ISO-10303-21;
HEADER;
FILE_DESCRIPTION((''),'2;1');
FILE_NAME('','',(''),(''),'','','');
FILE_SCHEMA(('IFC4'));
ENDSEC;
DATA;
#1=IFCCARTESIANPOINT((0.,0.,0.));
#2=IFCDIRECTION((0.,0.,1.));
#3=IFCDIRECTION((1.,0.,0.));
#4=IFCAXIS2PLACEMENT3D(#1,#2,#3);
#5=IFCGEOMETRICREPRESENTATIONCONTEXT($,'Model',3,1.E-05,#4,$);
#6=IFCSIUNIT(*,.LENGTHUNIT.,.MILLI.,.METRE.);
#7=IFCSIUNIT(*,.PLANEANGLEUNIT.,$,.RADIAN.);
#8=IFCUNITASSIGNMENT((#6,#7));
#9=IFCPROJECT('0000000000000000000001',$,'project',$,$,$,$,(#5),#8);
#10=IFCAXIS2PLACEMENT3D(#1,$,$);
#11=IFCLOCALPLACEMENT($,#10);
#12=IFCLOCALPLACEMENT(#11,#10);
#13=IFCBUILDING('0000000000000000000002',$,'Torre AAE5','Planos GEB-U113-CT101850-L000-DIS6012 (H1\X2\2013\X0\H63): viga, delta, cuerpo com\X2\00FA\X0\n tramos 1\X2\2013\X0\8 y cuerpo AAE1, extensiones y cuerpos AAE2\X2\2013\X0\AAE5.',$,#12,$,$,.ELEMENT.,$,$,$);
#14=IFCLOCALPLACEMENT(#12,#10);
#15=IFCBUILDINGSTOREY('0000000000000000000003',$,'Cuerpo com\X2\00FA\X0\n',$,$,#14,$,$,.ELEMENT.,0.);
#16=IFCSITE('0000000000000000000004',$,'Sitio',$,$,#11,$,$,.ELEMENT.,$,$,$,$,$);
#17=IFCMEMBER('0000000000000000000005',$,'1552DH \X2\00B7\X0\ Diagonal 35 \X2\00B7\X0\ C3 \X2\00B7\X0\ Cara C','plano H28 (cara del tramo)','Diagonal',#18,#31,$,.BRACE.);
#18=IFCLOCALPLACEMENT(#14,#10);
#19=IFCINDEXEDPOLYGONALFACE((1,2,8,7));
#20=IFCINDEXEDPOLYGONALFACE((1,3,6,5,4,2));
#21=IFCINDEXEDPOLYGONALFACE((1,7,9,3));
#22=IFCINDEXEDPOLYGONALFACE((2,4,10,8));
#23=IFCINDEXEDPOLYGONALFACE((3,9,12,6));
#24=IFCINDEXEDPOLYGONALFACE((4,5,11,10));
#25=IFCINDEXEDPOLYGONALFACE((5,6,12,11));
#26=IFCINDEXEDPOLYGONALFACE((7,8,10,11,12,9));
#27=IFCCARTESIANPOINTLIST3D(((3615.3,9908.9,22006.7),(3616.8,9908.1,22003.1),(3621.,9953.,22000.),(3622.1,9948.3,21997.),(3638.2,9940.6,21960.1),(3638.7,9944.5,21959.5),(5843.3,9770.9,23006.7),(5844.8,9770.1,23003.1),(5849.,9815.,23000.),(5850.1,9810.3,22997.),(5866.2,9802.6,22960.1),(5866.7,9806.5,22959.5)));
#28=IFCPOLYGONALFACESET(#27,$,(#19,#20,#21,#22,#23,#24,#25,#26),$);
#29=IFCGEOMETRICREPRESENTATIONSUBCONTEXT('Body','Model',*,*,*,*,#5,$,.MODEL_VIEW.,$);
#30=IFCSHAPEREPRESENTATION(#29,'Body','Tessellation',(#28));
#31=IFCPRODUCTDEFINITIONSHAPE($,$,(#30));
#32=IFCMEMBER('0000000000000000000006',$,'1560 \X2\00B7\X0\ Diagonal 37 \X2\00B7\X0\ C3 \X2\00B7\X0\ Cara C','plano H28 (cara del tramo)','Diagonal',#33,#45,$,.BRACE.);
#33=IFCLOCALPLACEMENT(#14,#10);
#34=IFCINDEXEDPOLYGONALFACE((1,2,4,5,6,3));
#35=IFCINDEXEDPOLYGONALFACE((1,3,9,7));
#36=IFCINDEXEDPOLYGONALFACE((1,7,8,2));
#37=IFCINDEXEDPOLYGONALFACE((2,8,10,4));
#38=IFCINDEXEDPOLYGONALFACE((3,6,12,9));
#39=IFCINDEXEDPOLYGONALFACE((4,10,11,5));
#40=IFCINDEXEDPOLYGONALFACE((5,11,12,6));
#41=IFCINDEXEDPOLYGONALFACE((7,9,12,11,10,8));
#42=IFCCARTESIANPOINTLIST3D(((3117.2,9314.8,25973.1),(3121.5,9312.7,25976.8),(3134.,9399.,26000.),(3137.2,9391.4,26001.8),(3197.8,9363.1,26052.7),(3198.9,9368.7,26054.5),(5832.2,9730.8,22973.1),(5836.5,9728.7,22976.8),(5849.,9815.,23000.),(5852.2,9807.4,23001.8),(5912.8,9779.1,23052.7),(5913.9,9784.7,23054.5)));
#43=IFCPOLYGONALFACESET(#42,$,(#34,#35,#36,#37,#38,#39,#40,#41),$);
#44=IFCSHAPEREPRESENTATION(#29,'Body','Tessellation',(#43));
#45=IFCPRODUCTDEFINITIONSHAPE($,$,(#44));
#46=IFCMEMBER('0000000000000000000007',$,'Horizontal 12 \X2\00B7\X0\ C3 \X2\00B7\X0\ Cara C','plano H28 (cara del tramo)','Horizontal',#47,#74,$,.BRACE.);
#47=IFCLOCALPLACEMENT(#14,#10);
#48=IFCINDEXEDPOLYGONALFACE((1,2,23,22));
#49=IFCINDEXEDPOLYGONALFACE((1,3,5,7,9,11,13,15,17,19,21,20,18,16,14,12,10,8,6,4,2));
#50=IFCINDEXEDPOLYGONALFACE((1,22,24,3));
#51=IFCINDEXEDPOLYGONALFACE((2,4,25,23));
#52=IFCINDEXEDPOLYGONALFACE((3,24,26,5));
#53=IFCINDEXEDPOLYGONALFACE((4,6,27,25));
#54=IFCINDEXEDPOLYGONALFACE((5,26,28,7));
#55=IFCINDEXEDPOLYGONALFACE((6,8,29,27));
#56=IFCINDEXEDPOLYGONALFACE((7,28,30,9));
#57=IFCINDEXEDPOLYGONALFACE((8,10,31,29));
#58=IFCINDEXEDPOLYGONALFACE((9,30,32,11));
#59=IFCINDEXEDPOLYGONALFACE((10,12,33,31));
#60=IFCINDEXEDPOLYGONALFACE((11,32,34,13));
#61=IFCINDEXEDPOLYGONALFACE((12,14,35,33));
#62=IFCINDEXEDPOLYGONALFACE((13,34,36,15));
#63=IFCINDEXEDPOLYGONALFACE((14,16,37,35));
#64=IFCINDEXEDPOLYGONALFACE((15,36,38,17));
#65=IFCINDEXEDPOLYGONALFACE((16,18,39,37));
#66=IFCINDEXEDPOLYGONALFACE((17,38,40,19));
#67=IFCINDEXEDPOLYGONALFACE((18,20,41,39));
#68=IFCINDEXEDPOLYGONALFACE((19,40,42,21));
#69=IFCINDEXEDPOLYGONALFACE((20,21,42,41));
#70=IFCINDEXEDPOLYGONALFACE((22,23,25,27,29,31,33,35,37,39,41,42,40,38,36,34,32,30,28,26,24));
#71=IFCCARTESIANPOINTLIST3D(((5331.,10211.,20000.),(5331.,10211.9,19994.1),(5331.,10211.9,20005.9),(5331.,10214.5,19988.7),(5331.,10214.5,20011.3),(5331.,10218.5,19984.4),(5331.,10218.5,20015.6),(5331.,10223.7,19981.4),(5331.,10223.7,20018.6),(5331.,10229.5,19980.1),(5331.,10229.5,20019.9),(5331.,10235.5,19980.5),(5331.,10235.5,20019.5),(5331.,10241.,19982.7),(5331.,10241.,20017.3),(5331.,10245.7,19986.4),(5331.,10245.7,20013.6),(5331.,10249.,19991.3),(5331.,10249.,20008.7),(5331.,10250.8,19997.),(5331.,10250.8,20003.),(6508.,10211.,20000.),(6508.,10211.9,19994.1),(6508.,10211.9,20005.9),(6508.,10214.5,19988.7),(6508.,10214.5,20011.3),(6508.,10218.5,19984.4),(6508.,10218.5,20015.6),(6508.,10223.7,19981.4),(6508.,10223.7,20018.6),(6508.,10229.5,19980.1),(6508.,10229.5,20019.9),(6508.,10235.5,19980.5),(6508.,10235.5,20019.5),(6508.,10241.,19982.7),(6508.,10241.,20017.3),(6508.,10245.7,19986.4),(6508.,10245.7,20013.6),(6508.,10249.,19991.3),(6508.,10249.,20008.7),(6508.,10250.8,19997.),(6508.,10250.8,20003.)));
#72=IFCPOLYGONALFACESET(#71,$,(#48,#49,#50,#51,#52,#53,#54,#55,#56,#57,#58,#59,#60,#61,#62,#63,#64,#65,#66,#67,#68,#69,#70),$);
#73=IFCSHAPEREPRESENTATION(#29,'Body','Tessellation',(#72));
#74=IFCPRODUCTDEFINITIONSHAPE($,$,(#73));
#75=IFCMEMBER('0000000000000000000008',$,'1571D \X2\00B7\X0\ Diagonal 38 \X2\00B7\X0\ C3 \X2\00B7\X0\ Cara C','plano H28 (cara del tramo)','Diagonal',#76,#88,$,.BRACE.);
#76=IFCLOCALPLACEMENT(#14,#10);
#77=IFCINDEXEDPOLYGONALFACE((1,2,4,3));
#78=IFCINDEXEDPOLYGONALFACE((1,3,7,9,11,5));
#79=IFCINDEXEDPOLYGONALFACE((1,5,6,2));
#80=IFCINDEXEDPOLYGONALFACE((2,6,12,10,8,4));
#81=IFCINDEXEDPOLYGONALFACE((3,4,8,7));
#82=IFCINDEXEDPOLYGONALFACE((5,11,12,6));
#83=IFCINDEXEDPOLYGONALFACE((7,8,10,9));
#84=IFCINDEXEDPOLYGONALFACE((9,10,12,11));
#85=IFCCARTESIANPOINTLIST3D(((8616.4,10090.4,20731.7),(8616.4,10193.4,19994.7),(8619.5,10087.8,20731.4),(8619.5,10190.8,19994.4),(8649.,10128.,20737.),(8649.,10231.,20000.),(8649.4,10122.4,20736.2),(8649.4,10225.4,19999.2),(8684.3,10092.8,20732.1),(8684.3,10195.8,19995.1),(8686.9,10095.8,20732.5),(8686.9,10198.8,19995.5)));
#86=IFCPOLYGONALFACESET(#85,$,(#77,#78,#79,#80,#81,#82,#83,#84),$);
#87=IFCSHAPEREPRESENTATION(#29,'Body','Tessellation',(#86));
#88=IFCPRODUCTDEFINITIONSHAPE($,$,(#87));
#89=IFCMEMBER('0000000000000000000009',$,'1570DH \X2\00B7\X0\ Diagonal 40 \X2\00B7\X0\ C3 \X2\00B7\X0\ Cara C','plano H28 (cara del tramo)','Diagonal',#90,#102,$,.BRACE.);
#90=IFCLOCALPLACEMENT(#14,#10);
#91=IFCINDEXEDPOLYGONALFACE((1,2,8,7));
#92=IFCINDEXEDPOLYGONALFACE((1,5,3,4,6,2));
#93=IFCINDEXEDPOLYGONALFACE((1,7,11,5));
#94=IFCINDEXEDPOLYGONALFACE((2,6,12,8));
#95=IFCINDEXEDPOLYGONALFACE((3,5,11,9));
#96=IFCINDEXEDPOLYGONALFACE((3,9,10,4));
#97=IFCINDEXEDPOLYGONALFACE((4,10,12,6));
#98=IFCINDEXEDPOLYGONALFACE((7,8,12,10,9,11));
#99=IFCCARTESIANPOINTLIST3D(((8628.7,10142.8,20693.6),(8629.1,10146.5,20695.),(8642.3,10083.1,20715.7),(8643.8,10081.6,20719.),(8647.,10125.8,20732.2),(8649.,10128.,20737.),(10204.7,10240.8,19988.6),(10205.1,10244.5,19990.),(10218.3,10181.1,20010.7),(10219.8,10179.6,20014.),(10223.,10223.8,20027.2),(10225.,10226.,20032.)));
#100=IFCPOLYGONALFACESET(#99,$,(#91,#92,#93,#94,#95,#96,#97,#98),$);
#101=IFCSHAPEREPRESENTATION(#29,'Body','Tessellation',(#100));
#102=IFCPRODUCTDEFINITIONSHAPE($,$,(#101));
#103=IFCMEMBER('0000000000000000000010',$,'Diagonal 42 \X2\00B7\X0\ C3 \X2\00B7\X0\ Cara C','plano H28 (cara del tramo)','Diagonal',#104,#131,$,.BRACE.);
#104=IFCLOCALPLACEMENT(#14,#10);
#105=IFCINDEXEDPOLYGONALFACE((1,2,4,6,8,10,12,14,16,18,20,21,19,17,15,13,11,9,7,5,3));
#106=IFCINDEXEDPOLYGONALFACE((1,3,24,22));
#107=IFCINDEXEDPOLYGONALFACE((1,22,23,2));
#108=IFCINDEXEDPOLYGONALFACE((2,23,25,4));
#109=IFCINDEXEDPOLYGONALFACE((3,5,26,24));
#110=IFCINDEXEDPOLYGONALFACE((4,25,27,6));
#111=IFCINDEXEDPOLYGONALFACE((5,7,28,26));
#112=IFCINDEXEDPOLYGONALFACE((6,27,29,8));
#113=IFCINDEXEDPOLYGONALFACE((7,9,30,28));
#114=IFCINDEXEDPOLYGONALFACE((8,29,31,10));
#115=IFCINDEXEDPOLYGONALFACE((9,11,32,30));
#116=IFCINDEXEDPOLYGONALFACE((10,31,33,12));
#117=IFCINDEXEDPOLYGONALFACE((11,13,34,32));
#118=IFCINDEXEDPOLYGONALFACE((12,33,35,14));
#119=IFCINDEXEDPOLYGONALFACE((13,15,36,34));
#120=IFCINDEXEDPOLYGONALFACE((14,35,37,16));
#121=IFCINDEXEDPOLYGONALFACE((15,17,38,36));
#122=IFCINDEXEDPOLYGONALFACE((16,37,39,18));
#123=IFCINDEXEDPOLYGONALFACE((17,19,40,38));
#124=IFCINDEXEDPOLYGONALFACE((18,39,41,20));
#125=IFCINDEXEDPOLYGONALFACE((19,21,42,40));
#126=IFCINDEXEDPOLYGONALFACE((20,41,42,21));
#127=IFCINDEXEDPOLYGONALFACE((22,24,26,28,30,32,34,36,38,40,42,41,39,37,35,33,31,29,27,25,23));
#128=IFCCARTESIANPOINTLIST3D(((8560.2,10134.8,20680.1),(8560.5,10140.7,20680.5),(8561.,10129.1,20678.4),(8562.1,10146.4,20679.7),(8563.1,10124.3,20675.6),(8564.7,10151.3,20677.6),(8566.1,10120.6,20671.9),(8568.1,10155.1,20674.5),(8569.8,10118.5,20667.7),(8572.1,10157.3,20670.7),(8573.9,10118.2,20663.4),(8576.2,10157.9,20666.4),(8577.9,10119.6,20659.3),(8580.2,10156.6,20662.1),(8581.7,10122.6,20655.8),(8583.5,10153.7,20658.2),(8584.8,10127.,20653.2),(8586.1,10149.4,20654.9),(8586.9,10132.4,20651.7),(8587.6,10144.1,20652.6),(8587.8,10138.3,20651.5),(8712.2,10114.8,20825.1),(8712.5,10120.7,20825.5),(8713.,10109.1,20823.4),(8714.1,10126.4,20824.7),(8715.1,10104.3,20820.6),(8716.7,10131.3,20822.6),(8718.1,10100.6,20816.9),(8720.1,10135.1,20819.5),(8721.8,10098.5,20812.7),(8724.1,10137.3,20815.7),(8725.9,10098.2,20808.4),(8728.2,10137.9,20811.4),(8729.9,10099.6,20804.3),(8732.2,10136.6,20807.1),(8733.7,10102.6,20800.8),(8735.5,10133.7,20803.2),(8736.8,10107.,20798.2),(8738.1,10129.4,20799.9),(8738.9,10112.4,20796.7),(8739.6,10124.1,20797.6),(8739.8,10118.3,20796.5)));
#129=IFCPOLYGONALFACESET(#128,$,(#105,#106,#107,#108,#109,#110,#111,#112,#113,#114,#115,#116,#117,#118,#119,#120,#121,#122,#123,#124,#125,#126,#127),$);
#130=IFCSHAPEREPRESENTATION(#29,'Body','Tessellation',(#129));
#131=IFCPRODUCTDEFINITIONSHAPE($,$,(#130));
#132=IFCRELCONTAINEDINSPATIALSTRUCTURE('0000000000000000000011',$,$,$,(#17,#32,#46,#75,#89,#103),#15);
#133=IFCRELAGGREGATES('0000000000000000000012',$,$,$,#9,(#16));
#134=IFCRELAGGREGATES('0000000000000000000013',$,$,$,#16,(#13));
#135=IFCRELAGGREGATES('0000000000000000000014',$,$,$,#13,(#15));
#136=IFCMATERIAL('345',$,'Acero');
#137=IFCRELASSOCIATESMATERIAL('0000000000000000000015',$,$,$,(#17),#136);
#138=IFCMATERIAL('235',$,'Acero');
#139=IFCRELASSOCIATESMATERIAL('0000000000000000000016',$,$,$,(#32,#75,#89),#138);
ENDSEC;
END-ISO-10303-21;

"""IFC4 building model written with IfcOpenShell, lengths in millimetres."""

from ifc_helpers import new_model, si_unit, frame, frame_2d, origin, origin_with_axes, place, context, subcontext, project, spatial, circle, l_section, extrude, material, element, save


model = new_model("IFC4")

# Units and contexts
model_context = context("Model", 3, precision=1e-05, world=origin_with_axes())
body_context = subcontext(model_context, "Body", "Model", "MODEL_VIEW")
ifc_project = project(units=[si_unit("LENGTHUNIT", "METRE", prefix="MILLI"), si_unit("PLANEANGLEUNIT", "RADIAN")], contexts=[model_context])

# Site, building, storey
site_placement = place(None, origin())
site = spatial("IfcSite", under=ifc_project, at=site_placement, Name="Sitio", CompositionType="ELEMENT")
building_placement = place(site_placement, origin())
building = spatial("IfcBuilding", under=site, at=building_placement, Name="Torre AAE5", Description="Planos GEB-U113-CT101850-L000-DIS6012 (H1–H63): viga, delta, cuerpo común tramos 1–8 y cuerpo AAE1, extensiones y cuerpos AAE2–AAE5.", CompositionType="ELEMENT")
storey_placement = place(building_placement, origin())
storey = spatial("IfcBuildingStorey", under=building, at=storey_placement, Name="Cuerpo común", CompositionType="ELEMENT", Elevation=0.0)

# Members
ifc_material_1 = material(Name="235", Category="Acero")
ifc_material_2 = material(Name="345", Category="Acero")
member_1_placement = place(storey_placement, frame((3621.0, 9953.0, 22000.0), z_axis=(0.910866, -0.056418, 0.408827), x_axis=(-0.12766, -0.980545, 0.149111)))
element("IfcMember", 1, at=member_1_placement, inside=storey, material=ifc_material_2, Name="1552DH · Diagonal 35 · C3 · Cara C", Description="plano H28 (cara del tramo)", ObjectType="Diagonal", PredefinedType="BRACE", context=body_context, shape_type="SweptSolid", body=[
    extrude(l_section(Depth=45.0, Width=45.0, Thickness=4.0, at=frame_2d((22.5, 22.5))), None, (0.0, 0.0, 1.0), 2446.0),
])
member_2_placement = place(storey_placement, frame((5849.0, 9815.0, 23000.0), z_axis=(-0.667492, -0.102275, 0.73756), x_axis=(-0.186627, -0.935928, -0.298679)))
element("IfcMember", 2, at=member_2_placement, inside=storey, material=ifc_material_1, Name="1560 · Diagonal 37 · C3 · Cara C", Description="plano H28 (cara del tramo)", ObjectType="Diagonal", PredefinedType="BRACE", context=body_context, shape_type="SweptSolid", body=[
    extrude(l_section(Depth=90.0, Width=90.0, Thickness=6.0, at=frame_2d((45.0, 45.0))), None, (0.0, 0.0, 1.0), 4067.5),
])
member_3_placement = place(storey_placement, frame((6508.0, 10231.0, 20000.0), z_axis=(-1.0, 0.0, 0.0), x_axis=(0.0, -1.0, 0.0)))
element("IfcMember", 3, at=member_3_placement, inside=storey, Name="Horizontal 12 · C3 · Cara C", Description="plano H28 (cara del tramo)", ObjectType="Horizontal", PredefinedType="BRACE", context=body_context, shape_type="SweptSolid", body=[
    extrude(circle(Radius=20.0), None, (0.0, 0.0, 1.0), 1177.0),
])
member_4_placement = place(storey_placement, frame((8649.0, 10231.0, 20000.0), z_axis=(0.0, -0.138411, 0.990375), x_axis=(-0.651125, -0.751665, -0.10505)))
element("IfcMember", 4, at=member_4_placement, inside=storey, material=ifc_material_1, Name="1571D · Diagonal 38 · C3 · Cara C", Description="plano H28 (cara del tramo)", ObjectType="Diagonal", PredefinedType="BRACE", context=body_context, shape_type="SweptSolid", body=[
    extrude(l_section(Depth=50.0, Width=50.0, Thickness=4.0, at=frame_2d((25.0, 25.0))), None, (0.0, 0.0, 1.0), 744.2),
])
member_5_placement = place(storey_placement, frame((8649.0, 10128.0, 20737.0), z_axis=(0.911363, 0.056671, -0.407684), x_axis=(-0.103073, -0.927495, -0.359344)))
element("IfcMember", 5, at=member_5_placement, inside=storey, material=ifc_material_1, Name="1570DH · Diagonal 40 · C3 · Cara C", Description="plano H28 (cara del tramo)", ObjectType="Diagonal", PredefinedType="BRACE", context=body_context, shape_type="SweptSolid", body=[
    extrude(l_section(Depth=50.0, Width=50.0, Thickness=4.0, at=frame_2d((25.0, 25.0))), None, (0.0, 0.0, 1.0), 1729.3),
])
member_6_placement = place(storey_placement, frame((8574.0, 10138.0, 20666.0), z_axis=(0.720314, -0.094778, 0.687142), x_axis=(-0.396782, -0.868845, 0.296096)))
element("IfcMember", 6, at=member_6_placement, inside=storey, Name="Diagonal 42 · C3 · Cara C", Description="plano H28 (cara del tramo)", ObjectType="Diagonal", PredefinedType="BRACE", context=body_context, shape_type="SweptSolid", body=[
    extrude(circle(Radius=20.0), None, (0.0, 0.0, 1.0), 211.0),
])

save(model, "model.ifc")
